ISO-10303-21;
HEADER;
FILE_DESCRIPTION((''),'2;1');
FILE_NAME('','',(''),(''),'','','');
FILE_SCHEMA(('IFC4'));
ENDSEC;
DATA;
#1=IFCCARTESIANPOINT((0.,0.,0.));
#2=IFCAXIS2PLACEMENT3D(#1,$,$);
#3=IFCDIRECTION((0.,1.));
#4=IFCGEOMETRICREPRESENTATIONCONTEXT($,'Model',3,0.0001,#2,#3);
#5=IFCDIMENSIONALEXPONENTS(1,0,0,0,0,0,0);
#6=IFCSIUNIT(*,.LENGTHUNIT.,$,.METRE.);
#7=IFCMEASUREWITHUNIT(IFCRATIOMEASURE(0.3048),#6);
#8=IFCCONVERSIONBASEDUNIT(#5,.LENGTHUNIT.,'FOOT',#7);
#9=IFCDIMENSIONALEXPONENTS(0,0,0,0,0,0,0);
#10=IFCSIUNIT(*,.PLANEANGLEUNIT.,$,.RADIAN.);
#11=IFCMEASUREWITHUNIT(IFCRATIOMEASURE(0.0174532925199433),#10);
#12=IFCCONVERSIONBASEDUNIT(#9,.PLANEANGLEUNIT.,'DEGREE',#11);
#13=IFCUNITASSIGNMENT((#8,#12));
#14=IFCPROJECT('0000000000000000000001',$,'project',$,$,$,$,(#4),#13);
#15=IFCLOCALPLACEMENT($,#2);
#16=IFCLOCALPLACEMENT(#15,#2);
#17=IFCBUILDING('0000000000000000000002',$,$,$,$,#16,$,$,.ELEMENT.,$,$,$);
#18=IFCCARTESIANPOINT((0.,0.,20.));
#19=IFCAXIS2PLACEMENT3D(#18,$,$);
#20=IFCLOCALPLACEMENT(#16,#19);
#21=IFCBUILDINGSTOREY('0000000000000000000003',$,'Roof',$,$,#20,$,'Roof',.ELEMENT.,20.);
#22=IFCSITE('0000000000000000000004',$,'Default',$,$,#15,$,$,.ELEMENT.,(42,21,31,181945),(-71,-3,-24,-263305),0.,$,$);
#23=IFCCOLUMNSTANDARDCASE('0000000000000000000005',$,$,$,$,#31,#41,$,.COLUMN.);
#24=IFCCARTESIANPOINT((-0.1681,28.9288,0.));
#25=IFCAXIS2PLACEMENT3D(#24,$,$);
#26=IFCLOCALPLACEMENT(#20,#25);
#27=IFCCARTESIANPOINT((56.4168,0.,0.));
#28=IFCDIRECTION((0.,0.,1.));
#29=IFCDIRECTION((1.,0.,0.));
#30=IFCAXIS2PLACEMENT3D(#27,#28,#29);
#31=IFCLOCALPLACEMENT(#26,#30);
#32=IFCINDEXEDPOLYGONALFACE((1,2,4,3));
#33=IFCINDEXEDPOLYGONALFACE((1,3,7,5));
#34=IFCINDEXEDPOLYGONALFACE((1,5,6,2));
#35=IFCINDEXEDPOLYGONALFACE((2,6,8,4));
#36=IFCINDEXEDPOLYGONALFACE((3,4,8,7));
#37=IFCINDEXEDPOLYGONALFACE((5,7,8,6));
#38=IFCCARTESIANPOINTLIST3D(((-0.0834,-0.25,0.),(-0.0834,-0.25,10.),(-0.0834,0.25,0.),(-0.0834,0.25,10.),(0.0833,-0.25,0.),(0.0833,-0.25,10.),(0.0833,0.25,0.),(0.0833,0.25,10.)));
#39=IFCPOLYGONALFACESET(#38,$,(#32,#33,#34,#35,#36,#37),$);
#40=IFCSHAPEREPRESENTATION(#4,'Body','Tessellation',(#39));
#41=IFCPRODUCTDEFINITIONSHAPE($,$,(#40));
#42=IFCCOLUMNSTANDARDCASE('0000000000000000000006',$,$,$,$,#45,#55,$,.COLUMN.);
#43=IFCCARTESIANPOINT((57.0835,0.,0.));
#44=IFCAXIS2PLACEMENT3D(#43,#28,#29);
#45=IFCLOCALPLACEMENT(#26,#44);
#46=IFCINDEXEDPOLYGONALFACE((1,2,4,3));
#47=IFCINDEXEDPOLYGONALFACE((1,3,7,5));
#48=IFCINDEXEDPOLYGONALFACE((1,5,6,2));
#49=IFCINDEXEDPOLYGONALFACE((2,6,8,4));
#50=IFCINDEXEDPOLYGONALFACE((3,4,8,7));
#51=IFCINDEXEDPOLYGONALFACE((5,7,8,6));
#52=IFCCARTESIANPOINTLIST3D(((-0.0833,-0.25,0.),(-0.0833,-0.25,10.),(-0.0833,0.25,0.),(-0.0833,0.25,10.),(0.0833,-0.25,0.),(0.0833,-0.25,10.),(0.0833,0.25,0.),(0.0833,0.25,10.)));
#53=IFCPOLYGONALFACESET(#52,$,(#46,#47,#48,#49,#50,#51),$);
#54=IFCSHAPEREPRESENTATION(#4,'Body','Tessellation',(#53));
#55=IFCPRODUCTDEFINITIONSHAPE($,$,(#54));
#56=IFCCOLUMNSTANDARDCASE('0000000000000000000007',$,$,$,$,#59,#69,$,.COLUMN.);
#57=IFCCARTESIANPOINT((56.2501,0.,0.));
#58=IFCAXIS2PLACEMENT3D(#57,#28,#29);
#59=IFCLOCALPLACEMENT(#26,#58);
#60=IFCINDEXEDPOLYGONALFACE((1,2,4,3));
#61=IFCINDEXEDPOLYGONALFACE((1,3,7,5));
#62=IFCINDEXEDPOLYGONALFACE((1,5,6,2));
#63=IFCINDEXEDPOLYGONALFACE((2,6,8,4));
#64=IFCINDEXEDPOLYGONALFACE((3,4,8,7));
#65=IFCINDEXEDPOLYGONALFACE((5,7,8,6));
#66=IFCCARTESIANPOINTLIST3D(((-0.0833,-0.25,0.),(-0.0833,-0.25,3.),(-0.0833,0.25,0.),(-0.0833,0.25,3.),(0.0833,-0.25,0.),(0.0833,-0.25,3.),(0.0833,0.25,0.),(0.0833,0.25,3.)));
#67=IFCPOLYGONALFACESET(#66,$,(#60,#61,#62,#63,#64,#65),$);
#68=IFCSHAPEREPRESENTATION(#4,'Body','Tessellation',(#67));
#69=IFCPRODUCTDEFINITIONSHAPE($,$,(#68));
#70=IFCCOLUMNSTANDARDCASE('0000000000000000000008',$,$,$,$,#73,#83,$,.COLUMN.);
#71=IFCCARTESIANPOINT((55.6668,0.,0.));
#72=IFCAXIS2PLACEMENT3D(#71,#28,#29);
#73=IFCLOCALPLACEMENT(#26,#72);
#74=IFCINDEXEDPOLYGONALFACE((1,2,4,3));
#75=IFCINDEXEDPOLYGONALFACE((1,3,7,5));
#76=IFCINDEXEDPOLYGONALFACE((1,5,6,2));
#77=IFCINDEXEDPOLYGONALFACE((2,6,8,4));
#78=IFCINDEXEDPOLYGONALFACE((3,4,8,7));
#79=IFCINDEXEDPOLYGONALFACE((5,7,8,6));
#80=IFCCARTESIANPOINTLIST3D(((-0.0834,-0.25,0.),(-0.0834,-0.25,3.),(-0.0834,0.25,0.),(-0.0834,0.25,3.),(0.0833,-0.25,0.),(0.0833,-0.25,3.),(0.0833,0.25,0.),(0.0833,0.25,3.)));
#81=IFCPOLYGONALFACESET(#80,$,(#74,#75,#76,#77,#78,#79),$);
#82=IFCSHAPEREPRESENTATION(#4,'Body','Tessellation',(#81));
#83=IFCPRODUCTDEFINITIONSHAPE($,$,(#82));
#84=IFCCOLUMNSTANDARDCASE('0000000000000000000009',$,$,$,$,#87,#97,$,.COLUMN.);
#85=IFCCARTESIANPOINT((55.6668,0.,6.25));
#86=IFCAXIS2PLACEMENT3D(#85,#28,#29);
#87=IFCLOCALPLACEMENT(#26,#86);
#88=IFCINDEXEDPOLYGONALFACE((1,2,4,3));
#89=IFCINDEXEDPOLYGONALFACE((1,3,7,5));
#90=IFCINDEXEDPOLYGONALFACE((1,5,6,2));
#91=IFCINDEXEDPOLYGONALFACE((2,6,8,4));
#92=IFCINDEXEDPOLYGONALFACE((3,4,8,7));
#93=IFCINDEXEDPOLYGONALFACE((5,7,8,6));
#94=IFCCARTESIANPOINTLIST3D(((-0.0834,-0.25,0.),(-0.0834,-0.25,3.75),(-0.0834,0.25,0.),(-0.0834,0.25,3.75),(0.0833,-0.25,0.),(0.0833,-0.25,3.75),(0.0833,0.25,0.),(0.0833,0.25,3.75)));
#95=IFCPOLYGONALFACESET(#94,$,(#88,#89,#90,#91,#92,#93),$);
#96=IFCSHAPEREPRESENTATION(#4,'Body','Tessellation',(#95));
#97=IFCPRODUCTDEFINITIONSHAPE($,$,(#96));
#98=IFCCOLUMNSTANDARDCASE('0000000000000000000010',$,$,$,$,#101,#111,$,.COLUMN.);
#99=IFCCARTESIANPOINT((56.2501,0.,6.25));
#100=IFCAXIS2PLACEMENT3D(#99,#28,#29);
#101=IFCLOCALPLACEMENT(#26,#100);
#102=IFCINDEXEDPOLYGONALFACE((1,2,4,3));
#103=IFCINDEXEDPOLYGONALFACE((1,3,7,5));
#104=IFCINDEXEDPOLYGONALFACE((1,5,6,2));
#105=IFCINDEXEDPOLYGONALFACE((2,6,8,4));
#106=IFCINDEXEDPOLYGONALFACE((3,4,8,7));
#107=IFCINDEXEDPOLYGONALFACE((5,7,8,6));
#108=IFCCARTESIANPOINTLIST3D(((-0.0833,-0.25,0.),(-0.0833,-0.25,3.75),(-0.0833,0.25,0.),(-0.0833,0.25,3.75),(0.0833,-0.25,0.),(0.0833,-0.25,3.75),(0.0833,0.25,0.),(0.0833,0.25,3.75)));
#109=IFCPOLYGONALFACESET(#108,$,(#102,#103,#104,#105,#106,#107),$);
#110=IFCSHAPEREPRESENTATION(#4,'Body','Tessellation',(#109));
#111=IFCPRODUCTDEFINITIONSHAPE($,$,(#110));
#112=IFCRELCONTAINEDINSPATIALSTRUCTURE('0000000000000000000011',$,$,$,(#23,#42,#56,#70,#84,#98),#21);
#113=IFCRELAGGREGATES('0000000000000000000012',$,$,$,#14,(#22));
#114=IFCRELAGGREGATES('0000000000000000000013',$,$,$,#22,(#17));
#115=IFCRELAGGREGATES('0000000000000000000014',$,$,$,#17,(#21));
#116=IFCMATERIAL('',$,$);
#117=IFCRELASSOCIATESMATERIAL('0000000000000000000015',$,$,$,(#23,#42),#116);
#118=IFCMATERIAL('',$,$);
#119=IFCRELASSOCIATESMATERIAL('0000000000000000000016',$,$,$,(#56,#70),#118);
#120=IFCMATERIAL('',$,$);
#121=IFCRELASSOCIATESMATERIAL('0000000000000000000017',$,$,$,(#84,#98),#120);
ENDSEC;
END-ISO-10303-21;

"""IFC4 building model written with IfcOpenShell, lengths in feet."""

from ifc_helpers import new_model, entity, si_unit, converted_unit, direction, frame, origin, place, context, project, spatial, rectangle, extrude, material, element, save


model = new_model("IFC4")

# Units and contexts
model_context = context("Model", 3, precision=0.0001, world=origin(), true_north=direction((0.0, 1.0)))
ifc_project = project(units=[converted_unit("LENGTHUNIT", "FOOT", entity("IfcRatioMeasure", 0.3048), si_unit("LENGTHUNIT", "METRE"), dimensions=[1, 0, 0, 0, 0, 0, 0]), converted_unit("PLANEANGLEUNIT", "DEGREE", entity("IfcRatioMeasure", 0.0174532925199433), si_unit("PLANEANGLEUNIT", "RADIAN"), dimensions=[0, 0, 0, 0, 0, 0, 0])], contexts=[model_context])

# Site, building, storey
site_placement = place(None, origin())
site = spatial("IfcSite", under=ifc_project, at=site_placement, Name="Default", CompositionType="ELEMENT", RefLatitude=(42, 21, 31, 181945), RefLongitude=(-71, -3, -24, -263305), RefElevation=0.0)
building_placement = place(site_placement, origin())
building = spatial("IfcBuilding", under=site, at=building_placement, CompositionType="ELEMENT")
storey_placement = place(building_placement, frame((0.0, 0.0, 20.0)))
storey = spatial("IfcBuildingStorey", under=building, at=storey_placement, Name="Roof", LongName="Roof", CompositionType="ELEMENT", Elevation=20.0)

# Columns
ifc_material_1 = material(Name="")
placement = place(storey_placement, frame((-0.1681, 28.9288, 0.0)))
for number, where, z_axis, x_axis in (
    (1, (56.4168, 0.0, 0.0), (0.0, 0.0, 1.0), (1.0, 0.0, 0.0)),
    (2, (57.0835, 0.0, 0.0), (0.0, 0.0, 1.0), (1.0, 0.0, 0.0)),
):
    element("IfcColumnStandardCase", number, at=place(placement, frame(where, z_axis=z_axis, x_axis=x_axis)), inside=storey, material=ifc_material_1, PredefinedType="COLUMN", context=model_context, shape_type="SweptSolid", body=[
        extrude(rectangle(XDim=0.1667, YDim=0.5), origin(), (0.0, 0.0, 1.0), 10.0),
    ])
ifc_material_2 = material(Name="")
for number, where, z_axis, x_axis in (
    (3, (56.2501, 0.0, 0.0), (0.0, 0.0, 1.0), (1.0, 0.0, 0.0)),
    (4, (55.6668, 0.0, 0.0), (0.0, 0.0, 1.0), (1.0, 0.0, 0.0)),
):
    element("IfcColumnStandardCase", number, at=place(placement, frame(where, z_axis=z_axis, x_axis=x_axis)), inside=storey, material=ifc_material_2, PredefinedType="COLUMN", context=model_context, shape_type="SweptSolid", body=[
        extrude(rectangle(XDim=0.1667, YDim=0.5), origin(), (0.0, 0.0, 1.0), 3.0),
    ])
ifc_material_3 = material(Name="")
for number, where, z_axis, x_axis in (
    (5, (55.6668, 0.0, 6.25), (0.0, 0.0, 1.0), (1.0, 0.0, 0.0)),
    (6, (56.2501, 0.0, 6.25), (0.0, 0.0, 1.0), (1.0, 0.0, 0.0)),
):
    element("IfcColumnStandardCase", number, at=place(placement, frame(where, z_axis=z_axis, x_axis=x_axis)), inside=storey, material=ifc_material_3, PredefinedType="COLUMN", context=model_context, shape_type="SweptSolid", body=[
        extrude(rectangle(XDim=0.1667, YDim=0.5), origin(), (0.0, 0.0, 1.0), 3.75),
    ])

save(model, "model.ifc")
